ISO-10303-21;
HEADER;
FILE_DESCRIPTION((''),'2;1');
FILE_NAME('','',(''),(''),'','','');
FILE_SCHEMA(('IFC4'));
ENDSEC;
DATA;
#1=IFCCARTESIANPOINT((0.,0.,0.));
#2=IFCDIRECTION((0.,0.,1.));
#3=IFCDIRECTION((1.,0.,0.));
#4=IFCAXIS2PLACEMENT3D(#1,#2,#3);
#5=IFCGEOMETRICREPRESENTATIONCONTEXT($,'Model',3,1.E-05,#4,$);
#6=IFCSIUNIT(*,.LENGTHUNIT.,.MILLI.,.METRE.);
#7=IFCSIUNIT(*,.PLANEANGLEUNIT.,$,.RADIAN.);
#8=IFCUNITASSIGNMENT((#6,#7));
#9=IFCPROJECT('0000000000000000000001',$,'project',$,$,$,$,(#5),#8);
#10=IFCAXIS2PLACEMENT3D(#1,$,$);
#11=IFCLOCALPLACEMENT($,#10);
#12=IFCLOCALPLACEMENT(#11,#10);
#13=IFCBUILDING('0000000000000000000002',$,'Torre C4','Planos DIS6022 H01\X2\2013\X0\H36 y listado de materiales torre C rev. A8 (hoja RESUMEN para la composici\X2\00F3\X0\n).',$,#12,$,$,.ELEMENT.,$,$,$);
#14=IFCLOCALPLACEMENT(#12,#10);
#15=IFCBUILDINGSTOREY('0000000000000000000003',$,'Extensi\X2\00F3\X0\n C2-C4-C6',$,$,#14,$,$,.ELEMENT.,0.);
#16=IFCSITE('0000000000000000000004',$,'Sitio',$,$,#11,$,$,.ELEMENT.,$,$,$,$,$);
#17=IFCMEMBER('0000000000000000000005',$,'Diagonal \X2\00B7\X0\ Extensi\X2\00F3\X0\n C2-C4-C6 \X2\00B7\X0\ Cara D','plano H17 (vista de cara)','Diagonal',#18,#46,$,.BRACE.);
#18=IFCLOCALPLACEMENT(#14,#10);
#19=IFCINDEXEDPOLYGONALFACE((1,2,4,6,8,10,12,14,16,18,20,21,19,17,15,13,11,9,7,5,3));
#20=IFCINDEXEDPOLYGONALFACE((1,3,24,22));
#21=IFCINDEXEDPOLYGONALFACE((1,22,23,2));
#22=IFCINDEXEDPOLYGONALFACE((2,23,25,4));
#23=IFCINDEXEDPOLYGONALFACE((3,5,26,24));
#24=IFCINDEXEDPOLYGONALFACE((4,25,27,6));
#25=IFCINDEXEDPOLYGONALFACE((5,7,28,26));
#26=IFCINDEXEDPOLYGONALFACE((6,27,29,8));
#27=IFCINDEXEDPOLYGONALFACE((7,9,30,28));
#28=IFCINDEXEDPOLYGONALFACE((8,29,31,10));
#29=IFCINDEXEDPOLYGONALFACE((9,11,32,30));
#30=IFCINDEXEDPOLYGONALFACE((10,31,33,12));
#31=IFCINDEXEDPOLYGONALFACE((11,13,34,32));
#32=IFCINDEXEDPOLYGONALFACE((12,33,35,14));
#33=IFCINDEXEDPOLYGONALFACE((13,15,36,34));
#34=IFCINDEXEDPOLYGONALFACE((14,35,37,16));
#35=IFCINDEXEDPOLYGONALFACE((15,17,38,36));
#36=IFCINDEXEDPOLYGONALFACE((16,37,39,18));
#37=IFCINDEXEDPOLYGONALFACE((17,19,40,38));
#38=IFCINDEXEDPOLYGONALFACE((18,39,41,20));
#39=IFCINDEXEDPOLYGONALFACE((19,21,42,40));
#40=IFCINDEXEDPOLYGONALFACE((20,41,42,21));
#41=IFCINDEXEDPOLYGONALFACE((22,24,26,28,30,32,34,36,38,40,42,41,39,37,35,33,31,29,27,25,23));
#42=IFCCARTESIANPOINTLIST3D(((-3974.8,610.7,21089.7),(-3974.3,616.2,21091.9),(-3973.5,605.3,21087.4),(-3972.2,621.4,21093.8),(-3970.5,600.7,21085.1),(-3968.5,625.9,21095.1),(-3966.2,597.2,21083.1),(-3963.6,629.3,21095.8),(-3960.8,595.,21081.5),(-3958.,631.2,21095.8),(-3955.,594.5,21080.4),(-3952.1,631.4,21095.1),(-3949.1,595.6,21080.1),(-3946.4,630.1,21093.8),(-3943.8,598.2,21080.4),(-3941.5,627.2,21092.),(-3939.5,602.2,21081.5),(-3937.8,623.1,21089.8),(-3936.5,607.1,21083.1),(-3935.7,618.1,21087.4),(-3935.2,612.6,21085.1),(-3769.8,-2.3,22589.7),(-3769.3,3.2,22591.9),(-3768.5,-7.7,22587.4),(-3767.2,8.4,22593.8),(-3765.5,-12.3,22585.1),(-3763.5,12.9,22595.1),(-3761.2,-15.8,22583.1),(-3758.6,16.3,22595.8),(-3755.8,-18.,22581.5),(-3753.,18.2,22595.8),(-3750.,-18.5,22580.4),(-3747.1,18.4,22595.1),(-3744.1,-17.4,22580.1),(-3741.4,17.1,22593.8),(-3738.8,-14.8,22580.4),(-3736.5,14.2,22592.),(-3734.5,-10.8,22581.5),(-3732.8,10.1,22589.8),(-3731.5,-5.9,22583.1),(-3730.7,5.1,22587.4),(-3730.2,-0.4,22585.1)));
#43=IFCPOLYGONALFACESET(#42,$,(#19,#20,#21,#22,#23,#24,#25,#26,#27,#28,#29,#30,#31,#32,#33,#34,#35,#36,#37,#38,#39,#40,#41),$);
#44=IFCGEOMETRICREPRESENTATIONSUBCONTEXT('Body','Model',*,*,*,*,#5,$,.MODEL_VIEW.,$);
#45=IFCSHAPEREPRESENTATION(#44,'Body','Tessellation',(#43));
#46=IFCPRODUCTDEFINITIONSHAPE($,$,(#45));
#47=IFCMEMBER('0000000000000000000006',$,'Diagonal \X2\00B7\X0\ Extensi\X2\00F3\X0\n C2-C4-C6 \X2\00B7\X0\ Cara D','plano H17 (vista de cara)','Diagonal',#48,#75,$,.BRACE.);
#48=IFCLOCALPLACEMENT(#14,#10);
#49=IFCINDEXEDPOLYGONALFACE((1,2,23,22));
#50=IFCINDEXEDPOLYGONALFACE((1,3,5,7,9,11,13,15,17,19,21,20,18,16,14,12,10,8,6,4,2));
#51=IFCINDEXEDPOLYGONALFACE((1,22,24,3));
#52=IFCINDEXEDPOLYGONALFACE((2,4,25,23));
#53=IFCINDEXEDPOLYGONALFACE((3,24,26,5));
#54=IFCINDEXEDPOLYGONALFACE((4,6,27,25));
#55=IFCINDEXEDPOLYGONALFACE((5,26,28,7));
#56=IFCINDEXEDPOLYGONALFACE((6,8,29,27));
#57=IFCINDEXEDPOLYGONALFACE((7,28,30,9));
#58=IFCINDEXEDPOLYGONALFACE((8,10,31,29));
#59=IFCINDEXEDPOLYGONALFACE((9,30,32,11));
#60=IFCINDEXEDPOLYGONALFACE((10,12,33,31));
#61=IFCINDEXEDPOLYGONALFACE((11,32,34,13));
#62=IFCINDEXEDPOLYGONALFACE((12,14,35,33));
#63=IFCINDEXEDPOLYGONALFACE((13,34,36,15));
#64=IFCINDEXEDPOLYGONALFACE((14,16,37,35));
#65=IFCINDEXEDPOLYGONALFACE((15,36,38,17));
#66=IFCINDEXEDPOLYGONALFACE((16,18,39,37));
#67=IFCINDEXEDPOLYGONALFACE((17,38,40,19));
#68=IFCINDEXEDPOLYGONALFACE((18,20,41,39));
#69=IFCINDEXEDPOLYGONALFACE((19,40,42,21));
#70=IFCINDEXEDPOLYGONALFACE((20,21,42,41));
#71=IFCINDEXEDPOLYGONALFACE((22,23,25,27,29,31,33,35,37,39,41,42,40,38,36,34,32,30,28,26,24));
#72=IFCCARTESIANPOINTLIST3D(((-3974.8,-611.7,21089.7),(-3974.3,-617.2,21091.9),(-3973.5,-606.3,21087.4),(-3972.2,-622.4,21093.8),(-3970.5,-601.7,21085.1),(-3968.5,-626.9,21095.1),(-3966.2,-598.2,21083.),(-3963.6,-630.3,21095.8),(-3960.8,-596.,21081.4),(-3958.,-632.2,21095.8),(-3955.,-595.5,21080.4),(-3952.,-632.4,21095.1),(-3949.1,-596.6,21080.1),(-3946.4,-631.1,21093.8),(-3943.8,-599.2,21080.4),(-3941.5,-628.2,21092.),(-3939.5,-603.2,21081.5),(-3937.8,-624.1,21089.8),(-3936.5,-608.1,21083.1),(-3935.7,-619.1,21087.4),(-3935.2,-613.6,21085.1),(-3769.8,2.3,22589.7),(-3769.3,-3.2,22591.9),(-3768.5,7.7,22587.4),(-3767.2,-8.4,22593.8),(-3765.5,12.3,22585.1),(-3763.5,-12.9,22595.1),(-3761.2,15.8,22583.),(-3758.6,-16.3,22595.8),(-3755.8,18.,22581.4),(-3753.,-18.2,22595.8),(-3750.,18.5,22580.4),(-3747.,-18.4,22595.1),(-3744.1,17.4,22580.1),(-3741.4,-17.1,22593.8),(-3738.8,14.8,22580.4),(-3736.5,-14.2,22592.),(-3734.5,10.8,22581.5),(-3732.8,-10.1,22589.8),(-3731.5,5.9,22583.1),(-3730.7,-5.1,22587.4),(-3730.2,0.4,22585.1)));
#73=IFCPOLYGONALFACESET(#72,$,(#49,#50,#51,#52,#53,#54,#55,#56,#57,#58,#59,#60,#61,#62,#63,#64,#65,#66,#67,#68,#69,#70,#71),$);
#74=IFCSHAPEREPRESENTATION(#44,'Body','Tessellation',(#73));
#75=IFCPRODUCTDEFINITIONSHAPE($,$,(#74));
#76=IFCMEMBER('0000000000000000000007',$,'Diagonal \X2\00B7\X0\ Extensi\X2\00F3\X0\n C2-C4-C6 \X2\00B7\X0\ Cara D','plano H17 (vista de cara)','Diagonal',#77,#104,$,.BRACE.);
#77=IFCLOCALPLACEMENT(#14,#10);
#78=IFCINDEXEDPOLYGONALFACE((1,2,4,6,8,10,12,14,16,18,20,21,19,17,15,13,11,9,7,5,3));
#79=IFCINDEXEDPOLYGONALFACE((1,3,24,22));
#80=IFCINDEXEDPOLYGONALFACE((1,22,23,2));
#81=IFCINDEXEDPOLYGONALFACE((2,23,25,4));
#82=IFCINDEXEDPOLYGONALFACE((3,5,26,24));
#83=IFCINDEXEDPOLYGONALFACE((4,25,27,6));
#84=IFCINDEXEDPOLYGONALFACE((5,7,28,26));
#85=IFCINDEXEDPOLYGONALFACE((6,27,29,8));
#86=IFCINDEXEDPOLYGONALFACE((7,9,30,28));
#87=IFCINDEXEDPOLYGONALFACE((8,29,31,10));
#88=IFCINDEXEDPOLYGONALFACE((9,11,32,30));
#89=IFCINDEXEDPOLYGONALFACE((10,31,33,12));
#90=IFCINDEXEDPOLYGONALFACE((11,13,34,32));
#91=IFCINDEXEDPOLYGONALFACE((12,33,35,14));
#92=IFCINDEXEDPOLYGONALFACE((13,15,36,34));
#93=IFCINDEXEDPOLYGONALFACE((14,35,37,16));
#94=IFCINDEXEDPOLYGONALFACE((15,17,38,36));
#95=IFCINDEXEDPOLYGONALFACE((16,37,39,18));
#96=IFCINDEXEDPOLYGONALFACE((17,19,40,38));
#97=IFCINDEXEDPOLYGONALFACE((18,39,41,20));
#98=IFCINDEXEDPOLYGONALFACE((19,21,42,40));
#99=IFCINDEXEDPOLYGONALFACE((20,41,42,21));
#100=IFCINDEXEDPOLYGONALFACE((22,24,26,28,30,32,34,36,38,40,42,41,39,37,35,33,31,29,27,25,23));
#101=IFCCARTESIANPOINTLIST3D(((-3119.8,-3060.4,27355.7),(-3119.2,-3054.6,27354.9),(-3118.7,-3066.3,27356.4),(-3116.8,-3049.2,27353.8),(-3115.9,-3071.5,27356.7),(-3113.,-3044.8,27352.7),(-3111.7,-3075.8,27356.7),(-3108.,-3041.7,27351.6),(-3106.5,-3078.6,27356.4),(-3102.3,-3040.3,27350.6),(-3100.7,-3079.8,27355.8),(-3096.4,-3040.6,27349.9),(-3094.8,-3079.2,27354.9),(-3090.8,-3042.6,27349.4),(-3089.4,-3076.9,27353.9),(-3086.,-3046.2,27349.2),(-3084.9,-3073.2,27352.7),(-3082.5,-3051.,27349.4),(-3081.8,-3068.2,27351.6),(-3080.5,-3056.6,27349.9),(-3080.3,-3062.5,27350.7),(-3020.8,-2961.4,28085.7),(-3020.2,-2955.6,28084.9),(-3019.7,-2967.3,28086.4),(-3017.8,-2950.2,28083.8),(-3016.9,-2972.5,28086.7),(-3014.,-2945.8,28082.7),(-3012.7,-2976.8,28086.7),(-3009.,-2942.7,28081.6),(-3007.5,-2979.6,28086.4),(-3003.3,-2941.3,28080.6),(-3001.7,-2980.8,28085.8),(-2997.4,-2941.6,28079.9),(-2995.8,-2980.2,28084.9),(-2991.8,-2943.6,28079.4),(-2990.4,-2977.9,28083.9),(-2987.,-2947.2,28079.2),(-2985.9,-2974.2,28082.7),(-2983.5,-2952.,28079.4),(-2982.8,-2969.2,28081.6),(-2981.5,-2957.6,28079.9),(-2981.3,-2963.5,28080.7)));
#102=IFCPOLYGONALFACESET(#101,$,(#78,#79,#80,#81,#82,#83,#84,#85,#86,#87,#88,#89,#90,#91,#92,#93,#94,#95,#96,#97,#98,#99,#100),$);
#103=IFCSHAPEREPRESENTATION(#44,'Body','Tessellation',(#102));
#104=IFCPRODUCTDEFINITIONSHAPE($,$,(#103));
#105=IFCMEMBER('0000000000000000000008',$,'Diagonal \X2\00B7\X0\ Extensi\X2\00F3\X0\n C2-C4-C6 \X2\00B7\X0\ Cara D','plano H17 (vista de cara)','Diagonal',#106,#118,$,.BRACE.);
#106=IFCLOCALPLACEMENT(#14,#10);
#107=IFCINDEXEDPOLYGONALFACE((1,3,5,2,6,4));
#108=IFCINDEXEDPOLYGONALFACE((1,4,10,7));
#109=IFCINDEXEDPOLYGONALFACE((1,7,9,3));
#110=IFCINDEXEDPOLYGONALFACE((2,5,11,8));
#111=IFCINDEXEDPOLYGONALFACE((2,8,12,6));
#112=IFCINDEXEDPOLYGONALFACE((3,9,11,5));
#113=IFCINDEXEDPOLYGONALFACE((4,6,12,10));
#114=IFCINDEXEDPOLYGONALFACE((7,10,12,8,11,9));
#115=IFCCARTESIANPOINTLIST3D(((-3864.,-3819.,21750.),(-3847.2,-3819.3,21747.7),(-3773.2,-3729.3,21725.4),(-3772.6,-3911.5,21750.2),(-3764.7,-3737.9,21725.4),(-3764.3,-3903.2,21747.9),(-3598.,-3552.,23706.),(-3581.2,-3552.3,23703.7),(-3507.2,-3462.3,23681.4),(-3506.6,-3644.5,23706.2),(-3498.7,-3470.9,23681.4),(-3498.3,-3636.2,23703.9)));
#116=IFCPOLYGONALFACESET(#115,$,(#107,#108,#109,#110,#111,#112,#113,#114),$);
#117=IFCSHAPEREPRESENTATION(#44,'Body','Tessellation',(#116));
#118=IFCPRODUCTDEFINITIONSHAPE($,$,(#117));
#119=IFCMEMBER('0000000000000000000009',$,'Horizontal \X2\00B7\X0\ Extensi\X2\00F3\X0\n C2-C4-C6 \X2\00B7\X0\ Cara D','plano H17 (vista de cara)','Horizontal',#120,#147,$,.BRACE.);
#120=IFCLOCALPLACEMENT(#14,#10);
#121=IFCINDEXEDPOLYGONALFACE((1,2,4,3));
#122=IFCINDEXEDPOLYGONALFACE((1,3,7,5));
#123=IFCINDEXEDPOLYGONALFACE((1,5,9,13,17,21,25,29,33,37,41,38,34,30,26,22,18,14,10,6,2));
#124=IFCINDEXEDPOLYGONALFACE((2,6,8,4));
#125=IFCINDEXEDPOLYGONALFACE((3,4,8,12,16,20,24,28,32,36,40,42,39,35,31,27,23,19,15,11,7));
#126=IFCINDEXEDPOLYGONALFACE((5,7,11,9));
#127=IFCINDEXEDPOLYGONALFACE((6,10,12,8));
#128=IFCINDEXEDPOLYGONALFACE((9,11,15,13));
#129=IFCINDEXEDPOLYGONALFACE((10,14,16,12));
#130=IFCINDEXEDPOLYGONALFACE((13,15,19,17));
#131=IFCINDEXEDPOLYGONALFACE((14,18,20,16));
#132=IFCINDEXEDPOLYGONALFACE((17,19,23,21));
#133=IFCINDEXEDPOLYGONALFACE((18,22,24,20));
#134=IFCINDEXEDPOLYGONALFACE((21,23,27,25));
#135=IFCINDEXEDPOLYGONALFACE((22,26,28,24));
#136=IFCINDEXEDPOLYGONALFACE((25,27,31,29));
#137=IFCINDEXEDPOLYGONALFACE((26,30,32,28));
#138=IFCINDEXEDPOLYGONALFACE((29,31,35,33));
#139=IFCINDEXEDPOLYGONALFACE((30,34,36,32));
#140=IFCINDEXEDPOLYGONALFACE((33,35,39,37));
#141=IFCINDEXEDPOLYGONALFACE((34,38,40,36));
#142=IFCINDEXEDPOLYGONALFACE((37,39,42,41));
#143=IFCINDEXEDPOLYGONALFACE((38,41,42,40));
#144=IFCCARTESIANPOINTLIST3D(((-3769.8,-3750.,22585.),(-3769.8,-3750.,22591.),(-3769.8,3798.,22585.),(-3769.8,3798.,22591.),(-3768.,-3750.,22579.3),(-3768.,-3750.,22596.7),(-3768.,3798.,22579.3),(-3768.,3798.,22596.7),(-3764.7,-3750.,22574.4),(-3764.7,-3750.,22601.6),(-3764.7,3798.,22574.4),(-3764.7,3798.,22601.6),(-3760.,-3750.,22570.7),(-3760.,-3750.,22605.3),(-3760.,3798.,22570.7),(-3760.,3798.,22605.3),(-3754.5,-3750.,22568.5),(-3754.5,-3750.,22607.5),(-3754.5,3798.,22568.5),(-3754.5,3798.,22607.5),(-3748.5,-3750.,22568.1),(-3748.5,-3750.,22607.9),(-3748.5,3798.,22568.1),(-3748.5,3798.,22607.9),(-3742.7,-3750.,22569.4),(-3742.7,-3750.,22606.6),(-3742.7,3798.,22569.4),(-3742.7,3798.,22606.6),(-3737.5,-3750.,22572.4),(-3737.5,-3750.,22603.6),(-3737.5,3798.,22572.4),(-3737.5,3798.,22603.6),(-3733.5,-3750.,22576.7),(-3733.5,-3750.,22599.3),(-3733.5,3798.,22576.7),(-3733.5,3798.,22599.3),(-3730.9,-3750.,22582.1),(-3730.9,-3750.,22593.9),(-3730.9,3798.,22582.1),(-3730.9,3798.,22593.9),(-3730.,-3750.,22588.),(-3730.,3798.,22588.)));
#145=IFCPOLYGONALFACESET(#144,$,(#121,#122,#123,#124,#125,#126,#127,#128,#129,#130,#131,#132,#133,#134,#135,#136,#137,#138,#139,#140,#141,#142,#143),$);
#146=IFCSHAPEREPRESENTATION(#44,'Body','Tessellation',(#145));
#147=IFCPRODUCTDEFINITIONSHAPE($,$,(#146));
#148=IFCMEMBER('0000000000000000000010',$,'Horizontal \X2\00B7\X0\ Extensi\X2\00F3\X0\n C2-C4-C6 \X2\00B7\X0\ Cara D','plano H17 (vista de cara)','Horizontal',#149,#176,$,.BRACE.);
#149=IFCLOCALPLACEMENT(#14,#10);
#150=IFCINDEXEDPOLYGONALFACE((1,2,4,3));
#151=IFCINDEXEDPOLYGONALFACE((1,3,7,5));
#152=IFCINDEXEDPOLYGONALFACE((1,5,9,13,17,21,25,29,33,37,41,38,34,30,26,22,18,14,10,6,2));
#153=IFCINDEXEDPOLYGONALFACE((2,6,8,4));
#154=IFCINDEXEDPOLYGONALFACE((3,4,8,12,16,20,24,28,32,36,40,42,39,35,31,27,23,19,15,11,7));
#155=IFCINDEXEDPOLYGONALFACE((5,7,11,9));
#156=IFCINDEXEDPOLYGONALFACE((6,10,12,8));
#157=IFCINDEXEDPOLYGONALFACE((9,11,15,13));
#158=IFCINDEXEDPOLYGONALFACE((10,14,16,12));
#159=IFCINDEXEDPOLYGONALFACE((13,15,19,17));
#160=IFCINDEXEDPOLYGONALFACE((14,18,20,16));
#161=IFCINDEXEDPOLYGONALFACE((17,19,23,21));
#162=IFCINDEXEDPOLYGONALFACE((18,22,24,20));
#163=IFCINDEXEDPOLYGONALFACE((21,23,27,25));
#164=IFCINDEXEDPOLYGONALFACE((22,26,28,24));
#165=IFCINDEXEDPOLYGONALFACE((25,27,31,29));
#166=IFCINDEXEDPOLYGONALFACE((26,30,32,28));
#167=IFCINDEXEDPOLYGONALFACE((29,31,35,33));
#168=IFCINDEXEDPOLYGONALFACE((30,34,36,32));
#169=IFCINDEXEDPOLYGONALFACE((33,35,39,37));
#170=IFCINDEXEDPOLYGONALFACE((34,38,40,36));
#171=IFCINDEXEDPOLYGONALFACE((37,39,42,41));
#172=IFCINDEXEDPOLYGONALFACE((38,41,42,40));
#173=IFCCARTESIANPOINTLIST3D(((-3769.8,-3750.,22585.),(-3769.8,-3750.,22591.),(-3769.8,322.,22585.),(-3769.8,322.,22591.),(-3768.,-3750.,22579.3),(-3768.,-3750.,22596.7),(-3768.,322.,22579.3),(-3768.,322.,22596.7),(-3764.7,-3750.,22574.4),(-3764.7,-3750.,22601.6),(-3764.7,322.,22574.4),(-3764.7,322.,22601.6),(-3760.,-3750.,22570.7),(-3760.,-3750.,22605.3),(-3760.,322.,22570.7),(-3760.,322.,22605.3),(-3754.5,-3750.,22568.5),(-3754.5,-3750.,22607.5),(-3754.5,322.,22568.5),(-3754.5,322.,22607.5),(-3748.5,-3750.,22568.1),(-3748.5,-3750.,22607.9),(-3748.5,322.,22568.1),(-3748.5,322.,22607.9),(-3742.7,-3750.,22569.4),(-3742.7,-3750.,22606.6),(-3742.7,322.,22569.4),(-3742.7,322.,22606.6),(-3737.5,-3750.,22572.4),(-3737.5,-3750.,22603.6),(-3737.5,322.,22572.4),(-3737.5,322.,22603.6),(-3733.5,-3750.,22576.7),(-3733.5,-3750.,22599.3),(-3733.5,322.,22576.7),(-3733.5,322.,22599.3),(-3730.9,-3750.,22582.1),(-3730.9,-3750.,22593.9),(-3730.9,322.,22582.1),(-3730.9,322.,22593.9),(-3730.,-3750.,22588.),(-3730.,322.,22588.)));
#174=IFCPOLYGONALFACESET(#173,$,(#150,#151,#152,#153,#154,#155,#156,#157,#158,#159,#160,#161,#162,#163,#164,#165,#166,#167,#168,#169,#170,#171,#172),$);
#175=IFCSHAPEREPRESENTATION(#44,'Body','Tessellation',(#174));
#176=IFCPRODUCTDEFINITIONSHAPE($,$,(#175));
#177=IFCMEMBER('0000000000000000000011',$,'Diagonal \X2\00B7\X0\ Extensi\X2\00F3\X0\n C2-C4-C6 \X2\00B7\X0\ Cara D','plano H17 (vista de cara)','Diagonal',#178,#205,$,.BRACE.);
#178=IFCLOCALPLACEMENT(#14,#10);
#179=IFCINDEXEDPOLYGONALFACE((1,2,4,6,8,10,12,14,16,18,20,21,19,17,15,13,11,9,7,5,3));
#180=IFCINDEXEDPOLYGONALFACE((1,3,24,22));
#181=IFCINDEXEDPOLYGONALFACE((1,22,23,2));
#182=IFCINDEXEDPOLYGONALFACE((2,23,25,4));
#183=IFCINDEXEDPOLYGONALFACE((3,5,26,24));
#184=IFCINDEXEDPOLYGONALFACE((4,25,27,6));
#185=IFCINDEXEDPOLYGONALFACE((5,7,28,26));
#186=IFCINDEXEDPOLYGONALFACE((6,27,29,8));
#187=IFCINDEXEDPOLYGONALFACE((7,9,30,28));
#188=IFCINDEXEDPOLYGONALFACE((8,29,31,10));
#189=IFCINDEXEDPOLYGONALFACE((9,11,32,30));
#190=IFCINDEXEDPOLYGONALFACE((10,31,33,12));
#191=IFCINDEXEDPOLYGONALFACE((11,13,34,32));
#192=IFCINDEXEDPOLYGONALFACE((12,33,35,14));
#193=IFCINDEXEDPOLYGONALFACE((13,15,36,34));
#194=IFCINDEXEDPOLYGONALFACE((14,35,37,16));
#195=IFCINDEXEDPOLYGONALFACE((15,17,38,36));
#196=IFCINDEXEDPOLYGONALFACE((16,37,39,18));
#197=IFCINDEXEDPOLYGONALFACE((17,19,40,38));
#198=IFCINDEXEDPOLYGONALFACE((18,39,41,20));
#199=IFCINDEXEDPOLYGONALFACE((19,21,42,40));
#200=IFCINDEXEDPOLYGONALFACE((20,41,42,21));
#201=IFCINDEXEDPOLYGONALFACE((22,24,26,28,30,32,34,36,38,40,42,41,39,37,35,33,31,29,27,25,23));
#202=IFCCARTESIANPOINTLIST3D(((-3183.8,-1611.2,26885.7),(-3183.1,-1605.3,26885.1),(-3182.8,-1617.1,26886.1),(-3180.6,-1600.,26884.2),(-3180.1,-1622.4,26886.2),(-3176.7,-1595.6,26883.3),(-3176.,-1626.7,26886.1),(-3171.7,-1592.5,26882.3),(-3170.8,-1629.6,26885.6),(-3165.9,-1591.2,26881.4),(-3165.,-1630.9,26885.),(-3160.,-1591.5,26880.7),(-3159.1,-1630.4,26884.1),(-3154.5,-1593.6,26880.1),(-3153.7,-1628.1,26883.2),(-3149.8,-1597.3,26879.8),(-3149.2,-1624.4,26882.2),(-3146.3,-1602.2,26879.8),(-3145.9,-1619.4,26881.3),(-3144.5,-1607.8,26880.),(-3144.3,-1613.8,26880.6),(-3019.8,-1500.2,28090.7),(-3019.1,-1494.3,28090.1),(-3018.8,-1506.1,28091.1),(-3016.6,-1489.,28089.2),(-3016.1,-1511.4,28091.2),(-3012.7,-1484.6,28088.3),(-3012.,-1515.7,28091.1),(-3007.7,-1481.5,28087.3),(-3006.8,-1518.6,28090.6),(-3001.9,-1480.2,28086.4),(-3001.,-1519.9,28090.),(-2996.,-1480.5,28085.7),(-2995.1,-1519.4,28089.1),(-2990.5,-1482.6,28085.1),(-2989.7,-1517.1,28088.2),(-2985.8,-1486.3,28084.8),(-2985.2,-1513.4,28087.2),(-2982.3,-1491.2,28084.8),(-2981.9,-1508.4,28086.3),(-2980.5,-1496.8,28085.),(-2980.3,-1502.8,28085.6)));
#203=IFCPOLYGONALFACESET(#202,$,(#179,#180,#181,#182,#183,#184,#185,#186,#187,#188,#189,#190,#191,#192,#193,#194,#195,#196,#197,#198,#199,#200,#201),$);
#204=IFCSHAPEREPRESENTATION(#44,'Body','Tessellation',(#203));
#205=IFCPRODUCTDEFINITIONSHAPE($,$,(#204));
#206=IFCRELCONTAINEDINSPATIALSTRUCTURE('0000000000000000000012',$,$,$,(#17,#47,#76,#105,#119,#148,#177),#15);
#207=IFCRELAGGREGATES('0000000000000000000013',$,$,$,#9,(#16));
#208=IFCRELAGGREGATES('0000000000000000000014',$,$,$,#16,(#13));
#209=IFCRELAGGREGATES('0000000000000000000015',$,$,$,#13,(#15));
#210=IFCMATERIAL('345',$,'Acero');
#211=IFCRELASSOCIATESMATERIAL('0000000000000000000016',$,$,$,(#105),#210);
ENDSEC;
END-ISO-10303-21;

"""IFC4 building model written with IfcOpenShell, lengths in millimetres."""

from ifc_helpers import new_model, si_unit, frame, frame_2d, origin, origin_with_axes, place, context, subcontext, project, spatial, circle, l_section, extrude, material, element, save


model = new_model("IFC4")

# Units and contexts
model_context = context("Model", 3, precision=1e-05, world=origin_with_axes())
body_context = subcontext(model_context, "Body", "Model", "MODEL_VIEW")
ifc_project = project(units=[si_unit("LENGTHUNIT", "METRE", prefix="MILLI"), si_unit("PLANEANGLEUNIT", "RADIAN")], contexts=[model_context])

# Site, building, storey
site_placement = place(None, origin())
site = spatial("IfcSite", under=ifc_project, at=site_placement, Name="Sitio", CompositionType="ELEMENT")
building_placement = place(site_placement, origin())
building = spatial("IfcBuilding", under=site, at=building_placement, Name="Torre C4", Description="Planos DIS6022 H01–H36 y listado de materiales torre C rev. A8 (hoja RESUMEN para la composición).", CompositionType="ELEMENT")
storey_placement = place(building_placement, origin())
storey = spatial("IfcBuildingStorey", under=building, at=storey_placement, Name="Extensión C2-C4-C6", CompositionType="ELEMENT", Elevation=0.0)

# Members
ifc_material_1 = material(Name="345", Category="Acero")
member_1_placement = place(storey_placement, frame((-3750.0, 0.0, 22588.0), z_axis=(-0.12551, 0.375305, -0.918365), x_axis=(0.989349, -0.02144, -0.143973)))
element("IfcMember", 1, at=member_1_placement, inside=storey, Name="Diagonal · Extensión C2-C4-C6 · Cara D", Description="plano H17 (vista de cara)", ObjectType="Diagonal", PredefinedType="BRACE", context=body_context, shape_type="SweptSolid", body=[
    extrude(circle(Radius=20.0), None, (0.0, 0.0, 1.0), 1633.3),
])
member_2_placement = place(storey_placement, frame((-3750.0, 0.0, 22588.0), z_axis=(-0.125481, -0.375831, -0.918153), x_axis=(0.989345, 0.021465, -0.143997)))
element("IfcMember", 2, at=member_2_placement, inside=storey, Name="Diagonal · Extensión C2-C4-C6 · Cara D", Description="plano H17 (vista de cara)", ObjectType="Diagonal", PredefinedType="BRACE", context=body_context, shape_type="SweptSolid", body=[
    extrude(circle(Radius=20.0), None, (0.0, 0.0, 1.0), 1633.7),
])
member_3_placement = place(storey_placement, frame((-3100.0, -3060.0, 27353.0), z_axis=(0.133189, 0.133189, 0.982101), x_axis=(0.699186, 0.689683, -0.188353)))
element("IfcMember", 3, at=member_3_placement, inside=storey, Name="Diagonal · Extensión C2-C4-C6 · Cara D", Description="plano H17 (vista de cara)", ObjectType="Diagonal", PredefinedType="BRACE", context=body_context, shape_type="SweptSolid", body=[
    extrude(circle(Radius=20.0), None, (0.0, 0.0, 1.0), 743.3),
])
member_4_placement = place(storey_placement, frame((-3598.0, -3552.0, 23706.0), z_axis=(-0.133536, -0.134038, -0.981938), x_axis=(0.698788, 0.689855, -0.189197)))
element("IfcMember", 4, at=member_4_placement, inside=storey, material=ifc_material_1, Name="Diagonal · Extensión C2-C4-C6 · Cara D", Description="plano H17 (vista de cara)", ObjectType="Diagonal", PredefinedType="BRACE", context=body_context, shape_type="SweptSolid", body=[
    extrude(l_section(Depth=130.0, Width=130.0, Thickness=12.0, at=frame_2d((65.0, 65.0))), None, (0.0, 0.0, 1.0), 1992.0),
])
member_5_placement = place(storey_placement, frame((-3750.0, -3750.0, 22588.0), z_axis=(0.0, 1.0, 0.0), x_axis=(1.0, 0.0, 0.0)))
element("IfcMember", 5, at=member_5_placement, inside=storey, Name="Horizontal · Extensión C2-C4-C6 · Cara D", Description="plano H17 (vista de cara)", ObjectType="Horizontal", PredefinedType="BRACE", context=body_context, shape_type="SweptSolid", body=[
    extrude(circle(Radius=20.0), None, (0.0, 0.0, 1.0), 7548.0),
])
member_6_placement = place(storey_placement, frame((-3750.0, -3750.0, 22588.0), z_axis=(0.0, 1.0, 0.0), x_axis=(1.0, 0.0, 0.0)))
element("IfcMember", 6, at=member_6_placement, inside=storey, Name="Horizontal · Extensión C2-C4-C6 · Cara D", Description="plano H17 (vista de cara)", ObjectType="Horizontal", PredefinedType="BRACE", context=body_context, shape_type="SweptSolid", body=[
    extrude(circle(Radius=20.0), None, (0.0, 0.0, 1.0), 4072.0),
])
member_7_placement = place(storey_placement, frame((-3000.0, -1500.0, 28088.0), z_axis=(-0.134298, -0.090897, -0.986763), x_axis=(0.882632, 0.441701, -0.160814)))
element("IfcMember", 7, at=member_7_placement, inside=storey, Name="Diagonal · Extensión C2-C4-C6 · Cara D", Description="plano H17 (vista de cara)", ObjectType="Diagonal", PredefinedType="BRACE", context=body_context, shape_type="SweptSolid", body=[
    extrude(circle(Radius=20.0), None, (0.0, 0.0, 1.0), 1221.2),
])

save(model, "model.ifc")
